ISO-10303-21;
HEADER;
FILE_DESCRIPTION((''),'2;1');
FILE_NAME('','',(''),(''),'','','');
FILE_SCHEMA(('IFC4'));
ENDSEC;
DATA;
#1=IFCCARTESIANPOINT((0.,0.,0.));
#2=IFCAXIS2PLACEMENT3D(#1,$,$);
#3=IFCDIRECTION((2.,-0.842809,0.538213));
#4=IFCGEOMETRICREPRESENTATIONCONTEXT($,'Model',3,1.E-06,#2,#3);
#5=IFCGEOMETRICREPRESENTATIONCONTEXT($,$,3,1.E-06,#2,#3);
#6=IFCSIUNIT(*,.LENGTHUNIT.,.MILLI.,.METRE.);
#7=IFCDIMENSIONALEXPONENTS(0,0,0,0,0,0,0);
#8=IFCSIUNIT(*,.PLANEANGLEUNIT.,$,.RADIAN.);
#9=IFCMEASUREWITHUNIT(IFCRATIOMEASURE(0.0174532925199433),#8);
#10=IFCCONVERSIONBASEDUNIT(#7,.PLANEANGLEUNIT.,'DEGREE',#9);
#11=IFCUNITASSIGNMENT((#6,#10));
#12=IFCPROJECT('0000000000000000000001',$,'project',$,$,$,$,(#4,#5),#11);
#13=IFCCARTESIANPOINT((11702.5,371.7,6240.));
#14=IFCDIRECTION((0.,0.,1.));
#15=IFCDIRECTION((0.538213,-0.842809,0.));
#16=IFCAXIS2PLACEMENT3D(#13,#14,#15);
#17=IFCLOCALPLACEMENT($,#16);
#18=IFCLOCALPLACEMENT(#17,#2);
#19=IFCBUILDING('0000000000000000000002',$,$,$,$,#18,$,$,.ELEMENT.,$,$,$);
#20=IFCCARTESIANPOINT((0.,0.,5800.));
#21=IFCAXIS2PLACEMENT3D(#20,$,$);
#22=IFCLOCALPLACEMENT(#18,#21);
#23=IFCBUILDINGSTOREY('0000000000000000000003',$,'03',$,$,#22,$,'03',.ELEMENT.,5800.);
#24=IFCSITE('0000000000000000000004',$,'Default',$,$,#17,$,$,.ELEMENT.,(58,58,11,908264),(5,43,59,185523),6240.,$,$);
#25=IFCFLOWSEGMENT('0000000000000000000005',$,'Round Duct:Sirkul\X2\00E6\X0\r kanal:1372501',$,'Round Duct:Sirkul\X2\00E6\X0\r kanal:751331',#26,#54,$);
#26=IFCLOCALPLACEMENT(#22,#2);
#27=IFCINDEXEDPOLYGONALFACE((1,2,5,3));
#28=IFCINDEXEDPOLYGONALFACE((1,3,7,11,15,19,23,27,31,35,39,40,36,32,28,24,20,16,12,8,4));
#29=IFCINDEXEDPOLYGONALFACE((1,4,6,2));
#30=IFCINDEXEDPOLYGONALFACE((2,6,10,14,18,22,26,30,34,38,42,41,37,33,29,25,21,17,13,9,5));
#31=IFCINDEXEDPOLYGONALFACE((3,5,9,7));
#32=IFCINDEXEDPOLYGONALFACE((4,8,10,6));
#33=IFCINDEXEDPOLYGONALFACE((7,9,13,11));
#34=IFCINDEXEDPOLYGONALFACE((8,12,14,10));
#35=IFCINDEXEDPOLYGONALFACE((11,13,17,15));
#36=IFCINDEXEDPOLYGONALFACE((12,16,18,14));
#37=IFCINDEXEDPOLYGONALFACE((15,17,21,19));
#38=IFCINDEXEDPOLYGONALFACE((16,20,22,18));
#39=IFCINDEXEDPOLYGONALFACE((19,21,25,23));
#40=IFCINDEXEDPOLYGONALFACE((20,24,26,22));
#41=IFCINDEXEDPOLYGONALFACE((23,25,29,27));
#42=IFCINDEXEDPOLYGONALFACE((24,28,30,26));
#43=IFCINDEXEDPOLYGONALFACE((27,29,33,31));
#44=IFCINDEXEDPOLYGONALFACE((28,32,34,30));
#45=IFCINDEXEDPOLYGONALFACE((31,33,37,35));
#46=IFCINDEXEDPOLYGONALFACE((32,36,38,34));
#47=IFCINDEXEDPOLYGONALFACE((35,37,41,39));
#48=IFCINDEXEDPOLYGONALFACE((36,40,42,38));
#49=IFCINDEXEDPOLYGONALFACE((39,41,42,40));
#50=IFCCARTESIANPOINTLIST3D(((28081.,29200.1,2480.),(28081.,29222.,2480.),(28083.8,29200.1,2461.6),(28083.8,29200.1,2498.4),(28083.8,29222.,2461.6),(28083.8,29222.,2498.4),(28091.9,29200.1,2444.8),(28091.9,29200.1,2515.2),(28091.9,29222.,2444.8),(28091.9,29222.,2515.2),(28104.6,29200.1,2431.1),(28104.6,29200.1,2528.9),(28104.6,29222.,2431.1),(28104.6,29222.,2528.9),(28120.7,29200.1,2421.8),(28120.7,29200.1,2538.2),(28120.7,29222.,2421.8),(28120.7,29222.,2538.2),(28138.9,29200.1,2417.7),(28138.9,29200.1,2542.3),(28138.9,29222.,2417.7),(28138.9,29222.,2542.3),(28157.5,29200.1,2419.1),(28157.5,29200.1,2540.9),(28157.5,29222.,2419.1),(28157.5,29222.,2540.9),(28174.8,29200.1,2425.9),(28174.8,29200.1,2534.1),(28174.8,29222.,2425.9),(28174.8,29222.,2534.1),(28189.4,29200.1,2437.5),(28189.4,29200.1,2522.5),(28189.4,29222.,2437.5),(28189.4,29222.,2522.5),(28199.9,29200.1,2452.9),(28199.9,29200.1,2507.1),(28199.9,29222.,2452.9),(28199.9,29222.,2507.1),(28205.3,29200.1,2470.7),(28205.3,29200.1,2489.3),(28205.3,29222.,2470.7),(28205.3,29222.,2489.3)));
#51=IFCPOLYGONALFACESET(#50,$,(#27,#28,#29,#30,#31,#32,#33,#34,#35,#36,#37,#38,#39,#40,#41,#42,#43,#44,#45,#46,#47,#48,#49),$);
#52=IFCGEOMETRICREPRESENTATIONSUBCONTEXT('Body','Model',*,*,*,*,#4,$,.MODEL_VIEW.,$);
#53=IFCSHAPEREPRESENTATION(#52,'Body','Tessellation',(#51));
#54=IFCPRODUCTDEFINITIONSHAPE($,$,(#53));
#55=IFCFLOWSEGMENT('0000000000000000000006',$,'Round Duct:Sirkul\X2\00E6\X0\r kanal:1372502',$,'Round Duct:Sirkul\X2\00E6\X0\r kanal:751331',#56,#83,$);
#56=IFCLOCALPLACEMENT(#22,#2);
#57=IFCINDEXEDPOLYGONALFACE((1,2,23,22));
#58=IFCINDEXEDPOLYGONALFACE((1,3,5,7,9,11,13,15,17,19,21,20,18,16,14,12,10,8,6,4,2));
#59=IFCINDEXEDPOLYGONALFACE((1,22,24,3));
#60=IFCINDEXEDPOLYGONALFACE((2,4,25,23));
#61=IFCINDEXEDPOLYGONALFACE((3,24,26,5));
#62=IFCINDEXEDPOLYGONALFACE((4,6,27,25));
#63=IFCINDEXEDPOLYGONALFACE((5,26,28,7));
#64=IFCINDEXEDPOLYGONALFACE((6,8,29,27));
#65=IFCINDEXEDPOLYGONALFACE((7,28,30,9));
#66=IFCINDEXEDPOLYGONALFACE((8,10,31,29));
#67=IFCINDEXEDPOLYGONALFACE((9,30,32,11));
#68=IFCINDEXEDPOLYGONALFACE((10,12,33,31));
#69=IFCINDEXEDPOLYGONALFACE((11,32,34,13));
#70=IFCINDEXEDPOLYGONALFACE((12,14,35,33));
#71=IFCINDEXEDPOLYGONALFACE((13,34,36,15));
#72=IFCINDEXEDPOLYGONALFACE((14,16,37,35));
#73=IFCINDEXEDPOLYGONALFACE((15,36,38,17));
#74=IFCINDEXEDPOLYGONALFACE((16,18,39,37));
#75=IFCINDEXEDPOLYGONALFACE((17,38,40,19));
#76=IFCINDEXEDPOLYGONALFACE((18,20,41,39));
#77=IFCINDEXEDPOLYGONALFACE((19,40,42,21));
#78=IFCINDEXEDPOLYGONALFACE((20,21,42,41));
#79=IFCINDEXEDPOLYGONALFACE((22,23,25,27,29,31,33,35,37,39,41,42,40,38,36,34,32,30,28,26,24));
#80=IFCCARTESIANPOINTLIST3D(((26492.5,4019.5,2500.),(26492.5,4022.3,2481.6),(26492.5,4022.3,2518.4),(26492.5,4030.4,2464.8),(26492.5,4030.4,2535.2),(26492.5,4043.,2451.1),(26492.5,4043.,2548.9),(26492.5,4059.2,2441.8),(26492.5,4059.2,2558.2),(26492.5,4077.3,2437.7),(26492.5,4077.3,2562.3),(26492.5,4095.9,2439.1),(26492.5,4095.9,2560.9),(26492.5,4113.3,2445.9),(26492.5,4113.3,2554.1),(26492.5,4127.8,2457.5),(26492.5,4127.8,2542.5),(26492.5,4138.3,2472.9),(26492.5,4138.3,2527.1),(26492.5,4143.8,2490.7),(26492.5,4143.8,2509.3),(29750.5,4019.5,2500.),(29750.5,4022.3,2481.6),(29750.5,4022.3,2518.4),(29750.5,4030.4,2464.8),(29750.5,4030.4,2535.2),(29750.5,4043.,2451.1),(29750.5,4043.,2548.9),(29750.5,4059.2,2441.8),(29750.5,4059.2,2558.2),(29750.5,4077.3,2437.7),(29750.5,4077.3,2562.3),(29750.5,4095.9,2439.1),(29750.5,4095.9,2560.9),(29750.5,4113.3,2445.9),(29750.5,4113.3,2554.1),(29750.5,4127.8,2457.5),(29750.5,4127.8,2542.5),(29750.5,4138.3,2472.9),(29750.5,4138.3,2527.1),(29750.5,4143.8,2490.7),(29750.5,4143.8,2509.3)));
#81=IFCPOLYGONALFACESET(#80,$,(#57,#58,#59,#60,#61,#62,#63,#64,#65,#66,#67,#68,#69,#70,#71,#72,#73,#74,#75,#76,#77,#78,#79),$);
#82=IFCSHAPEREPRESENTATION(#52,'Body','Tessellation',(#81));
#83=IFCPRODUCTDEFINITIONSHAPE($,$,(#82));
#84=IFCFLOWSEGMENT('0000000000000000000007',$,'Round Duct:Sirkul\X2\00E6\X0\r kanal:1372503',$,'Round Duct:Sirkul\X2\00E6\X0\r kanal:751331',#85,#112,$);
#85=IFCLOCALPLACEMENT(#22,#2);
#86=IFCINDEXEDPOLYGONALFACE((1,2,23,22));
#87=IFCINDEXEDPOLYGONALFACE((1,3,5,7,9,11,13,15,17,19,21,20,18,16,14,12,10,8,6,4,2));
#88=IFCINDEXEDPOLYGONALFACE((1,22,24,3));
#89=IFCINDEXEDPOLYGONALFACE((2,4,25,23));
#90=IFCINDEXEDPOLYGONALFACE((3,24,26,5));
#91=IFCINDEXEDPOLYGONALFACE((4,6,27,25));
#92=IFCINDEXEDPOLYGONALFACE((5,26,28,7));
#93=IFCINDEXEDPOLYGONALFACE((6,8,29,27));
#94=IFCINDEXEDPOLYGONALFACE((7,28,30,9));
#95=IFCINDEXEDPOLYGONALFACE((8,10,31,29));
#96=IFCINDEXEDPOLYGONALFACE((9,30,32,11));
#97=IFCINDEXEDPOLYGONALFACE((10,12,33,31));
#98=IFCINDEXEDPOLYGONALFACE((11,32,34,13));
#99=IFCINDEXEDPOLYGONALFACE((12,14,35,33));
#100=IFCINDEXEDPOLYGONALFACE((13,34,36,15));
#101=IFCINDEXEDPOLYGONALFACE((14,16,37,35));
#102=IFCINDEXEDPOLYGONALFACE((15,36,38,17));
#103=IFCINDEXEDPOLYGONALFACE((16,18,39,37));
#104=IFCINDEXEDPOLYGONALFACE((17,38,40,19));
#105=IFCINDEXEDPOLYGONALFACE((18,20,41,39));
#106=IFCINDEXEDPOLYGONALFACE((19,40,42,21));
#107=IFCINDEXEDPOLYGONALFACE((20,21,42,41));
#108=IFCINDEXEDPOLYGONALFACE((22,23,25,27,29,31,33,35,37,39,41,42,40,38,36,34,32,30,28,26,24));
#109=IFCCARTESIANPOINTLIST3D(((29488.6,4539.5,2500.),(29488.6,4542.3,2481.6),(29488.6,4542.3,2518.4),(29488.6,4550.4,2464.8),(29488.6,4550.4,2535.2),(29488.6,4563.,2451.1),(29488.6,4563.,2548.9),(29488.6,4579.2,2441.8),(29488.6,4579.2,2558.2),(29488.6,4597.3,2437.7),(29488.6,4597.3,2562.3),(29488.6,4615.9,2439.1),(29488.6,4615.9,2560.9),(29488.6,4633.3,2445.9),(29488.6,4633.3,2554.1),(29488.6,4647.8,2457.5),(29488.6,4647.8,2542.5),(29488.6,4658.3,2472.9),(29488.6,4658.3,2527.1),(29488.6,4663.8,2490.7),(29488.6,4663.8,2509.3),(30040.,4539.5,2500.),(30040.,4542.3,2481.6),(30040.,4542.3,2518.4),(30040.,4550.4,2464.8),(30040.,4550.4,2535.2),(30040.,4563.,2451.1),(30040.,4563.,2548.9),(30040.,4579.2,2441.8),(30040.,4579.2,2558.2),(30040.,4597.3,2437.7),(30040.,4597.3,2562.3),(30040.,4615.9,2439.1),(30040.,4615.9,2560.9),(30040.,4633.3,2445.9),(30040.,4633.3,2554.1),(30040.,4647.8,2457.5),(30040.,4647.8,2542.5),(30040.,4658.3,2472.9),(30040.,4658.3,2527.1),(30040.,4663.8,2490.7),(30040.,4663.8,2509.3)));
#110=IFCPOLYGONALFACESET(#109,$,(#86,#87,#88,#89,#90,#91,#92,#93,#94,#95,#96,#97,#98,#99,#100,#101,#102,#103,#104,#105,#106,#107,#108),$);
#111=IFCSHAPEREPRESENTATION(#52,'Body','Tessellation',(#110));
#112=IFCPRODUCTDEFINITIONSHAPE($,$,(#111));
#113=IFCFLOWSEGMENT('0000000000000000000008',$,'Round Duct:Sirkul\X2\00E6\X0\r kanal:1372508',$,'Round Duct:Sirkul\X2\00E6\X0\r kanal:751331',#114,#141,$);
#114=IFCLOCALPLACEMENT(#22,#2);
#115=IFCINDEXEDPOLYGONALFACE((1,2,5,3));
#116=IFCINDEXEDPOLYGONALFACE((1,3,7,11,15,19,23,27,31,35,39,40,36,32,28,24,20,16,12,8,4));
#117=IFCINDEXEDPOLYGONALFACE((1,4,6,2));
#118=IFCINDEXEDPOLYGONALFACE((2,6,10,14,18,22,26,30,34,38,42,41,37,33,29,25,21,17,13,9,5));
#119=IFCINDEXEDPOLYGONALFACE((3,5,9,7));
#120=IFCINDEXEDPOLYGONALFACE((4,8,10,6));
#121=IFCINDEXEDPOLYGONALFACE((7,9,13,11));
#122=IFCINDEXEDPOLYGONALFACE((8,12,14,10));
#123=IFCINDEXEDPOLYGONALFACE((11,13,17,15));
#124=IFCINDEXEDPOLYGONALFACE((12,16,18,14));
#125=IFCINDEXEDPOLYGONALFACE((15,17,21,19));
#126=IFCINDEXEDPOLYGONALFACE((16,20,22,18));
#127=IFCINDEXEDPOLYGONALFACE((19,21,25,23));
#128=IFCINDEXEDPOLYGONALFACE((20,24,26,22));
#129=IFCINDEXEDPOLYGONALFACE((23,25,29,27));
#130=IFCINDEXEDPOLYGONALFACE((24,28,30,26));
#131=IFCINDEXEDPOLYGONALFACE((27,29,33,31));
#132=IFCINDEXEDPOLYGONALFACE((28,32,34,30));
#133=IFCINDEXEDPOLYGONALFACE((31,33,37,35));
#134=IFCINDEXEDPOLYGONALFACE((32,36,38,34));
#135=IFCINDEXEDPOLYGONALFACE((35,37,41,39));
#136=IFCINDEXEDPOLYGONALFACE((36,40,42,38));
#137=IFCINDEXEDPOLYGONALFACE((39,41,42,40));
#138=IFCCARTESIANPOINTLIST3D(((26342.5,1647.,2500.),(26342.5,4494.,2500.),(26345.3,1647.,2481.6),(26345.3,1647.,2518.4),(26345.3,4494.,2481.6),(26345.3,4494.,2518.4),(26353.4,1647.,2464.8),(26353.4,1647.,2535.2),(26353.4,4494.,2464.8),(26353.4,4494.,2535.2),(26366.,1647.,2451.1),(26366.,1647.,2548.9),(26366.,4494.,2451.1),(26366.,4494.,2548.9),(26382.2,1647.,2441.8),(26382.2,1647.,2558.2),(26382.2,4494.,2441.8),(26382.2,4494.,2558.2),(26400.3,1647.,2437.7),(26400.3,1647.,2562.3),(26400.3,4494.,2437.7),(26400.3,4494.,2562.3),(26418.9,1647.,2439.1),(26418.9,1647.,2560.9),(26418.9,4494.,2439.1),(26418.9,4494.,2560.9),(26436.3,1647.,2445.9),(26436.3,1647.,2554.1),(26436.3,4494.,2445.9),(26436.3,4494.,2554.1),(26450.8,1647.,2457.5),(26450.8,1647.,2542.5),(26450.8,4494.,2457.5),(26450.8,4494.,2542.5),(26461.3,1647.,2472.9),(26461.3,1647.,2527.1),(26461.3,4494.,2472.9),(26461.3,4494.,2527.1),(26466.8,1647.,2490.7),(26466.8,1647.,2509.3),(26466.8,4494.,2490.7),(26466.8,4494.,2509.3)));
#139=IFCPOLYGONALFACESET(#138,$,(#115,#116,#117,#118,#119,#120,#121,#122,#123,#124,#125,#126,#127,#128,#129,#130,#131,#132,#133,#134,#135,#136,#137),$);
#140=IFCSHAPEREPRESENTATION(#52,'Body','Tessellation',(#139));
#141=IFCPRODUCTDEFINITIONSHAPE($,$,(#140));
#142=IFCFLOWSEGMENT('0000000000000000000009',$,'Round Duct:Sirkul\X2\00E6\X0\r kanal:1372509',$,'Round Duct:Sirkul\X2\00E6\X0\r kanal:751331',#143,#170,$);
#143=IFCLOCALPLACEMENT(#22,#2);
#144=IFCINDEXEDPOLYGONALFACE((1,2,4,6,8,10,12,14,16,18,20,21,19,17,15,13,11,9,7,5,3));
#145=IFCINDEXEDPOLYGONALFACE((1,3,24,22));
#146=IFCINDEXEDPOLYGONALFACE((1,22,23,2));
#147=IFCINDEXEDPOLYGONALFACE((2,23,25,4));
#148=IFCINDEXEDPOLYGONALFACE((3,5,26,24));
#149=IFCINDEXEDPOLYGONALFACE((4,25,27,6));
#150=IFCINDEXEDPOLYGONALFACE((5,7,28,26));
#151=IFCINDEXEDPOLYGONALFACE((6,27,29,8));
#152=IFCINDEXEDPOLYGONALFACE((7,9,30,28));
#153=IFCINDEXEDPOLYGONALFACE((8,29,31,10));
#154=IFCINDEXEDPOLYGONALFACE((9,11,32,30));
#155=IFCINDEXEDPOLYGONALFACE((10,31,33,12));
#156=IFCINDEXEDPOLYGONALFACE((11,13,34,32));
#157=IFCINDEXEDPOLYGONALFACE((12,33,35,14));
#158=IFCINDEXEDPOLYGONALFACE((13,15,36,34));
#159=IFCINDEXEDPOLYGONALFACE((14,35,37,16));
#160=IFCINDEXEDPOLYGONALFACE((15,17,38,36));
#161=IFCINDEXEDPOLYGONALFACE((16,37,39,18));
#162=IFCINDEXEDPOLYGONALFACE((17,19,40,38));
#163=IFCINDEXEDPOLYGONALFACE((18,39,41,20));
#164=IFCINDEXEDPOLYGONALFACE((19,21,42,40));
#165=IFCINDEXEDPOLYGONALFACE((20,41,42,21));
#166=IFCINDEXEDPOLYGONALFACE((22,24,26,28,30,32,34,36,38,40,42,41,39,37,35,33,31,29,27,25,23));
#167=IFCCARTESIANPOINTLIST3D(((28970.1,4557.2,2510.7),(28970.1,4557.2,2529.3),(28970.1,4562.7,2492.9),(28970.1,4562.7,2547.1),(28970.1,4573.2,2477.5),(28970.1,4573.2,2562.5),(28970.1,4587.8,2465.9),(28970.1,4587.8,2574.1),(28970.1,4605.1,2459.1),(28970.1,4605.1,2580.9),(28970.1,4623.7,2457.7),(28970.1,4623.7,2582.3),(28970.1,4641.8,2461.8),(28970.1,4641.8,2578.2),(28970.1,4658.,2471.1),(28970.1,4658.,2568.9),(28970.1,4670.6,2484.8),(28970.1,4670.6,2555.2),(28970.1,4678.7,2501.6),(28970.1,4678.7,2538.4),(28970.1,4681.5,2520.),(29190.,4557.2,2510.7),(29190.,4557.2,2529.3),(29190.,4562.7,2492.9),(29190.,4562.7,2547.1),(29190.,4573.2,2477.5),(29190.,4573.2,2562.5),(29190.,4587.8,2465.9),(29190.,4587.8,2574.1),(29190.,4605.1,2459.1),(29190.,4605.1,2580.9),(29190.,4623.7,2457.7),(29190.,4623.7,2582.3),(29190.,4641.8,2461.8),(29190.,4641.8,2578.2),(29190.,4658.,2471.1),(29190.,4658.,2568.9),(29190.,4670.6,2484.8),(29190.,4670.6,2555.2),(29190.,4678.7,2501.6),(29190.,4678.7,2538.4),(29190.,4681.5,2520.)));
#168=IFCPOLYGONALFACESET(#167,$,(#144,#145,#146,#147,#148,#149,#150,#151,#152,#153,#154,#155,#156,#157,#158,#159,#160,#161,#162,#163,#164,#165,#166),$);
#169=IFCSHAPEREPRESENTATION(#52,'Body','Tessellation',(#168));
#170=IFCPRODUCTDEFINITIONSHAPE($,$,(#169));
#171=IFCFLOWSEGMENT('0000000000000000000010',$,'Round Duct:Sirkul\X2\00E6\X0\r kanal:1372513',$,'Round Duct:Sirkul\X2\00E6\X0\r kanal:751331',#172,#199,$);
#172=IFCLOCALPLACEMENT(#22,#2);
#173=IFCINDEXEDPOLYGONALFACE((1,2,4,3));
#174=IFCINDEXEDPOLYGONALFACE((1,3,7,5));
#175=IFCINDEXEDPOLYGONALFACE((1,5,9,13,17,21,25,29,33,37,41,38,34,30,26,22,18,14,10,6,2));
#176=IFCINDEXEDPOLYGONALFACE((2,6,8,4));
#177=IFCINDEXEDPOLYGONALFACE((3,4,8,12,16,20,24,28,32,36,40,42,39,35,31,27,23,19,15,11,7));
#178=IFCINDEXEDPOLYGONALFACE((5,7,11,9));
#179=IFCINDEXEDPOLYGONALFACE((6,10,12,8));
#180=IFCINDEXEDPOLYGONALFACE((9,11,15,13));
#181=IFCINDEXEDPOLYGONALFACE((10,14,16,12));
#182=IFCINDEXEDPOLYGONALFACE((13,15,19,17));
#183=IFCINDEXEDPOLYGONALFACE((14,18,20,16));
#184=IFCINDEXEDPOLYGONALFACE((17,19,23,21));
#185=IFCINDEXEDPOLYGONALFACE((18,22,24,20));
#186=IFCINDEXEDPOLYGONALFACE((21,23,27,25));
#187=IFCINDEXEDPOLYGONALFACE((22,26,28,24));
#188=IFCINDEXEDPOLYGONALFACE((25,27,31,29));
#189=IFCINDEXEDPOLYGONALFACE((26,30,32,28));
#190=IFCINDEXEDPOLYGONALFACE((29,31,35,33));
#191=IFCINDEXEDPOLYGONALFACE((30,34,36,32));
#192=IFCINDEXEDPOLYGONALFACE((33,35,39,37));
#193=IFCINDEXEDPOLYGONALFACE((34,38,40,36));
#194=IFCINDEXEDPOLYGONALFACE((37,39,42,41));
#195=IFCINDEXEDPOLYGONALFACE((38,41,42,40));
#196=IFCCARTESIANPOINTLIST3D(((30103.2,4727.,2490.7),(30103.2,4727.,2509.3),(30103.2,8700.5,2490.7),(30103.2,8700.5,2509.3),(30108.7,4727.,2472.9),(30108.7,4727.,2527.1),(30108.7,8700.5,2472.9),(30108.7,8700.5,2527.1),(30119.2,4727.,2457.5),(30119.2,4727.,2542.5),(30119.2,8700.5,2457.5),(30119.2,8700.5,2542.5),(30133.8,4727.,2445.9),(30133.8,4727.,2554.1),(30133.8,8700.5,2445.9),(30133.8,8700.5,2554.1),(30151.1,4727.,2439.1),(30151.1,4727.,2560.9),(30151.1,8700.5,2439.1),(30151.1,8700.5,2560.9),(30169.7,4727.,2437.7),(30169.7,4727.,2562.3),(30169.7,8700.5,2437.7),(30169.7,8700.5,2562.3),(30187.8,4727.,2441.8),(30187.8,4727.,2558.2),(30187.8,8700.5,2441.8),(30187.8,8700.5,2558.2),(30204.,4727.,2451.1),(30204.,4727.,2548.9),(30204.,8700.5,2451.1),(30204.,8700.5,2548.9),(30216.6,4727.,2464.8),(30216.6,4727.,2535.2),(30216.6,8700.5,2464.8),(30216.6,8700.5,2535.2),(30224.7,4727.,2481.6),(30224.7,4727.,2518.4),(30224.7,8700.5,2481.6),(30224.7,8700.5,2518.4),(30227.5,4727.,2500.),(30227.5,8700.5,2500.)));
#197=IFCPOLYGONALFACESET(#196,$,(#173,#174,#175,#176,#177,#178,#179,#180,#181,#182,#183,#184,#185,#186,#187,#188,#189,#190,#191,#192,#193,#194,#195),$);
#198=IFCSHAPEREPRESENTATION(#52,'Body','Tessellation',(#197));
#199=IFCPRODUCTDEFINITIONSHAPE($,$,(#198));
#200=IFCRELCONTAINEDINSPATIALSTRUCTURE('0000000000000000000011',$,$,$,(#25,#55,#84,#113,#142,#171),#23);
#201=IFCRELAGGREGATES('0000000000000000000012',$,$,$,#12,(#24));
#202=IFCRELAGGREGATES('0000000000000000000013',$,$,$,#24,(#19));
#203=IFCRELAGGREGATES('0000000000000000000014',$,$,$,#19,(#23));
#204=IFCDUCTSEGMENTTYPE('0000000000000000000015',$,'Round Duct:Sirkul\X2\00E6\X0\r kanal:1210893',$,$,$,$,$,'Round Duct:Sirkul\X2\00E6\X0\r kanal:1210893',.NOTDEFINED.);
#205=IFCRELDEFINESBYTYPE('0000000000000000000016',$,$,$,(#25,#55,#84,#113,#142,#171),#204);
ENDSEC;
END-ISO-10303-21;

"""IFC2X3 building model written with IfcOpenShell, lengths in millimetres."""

from ifc_helpers import new_model, entity, si_unit, converted_unit, direction, frame, frame_2d, origin, origin_2d_with_axis, place, context, subcontext, project, spatial, circle, extrude, type_object, element, save


model = new_model("IFC2X3")

# Units and contexts
model_context = context("Model", 3, precision=1e-06, world=origin(), true_north=direction((2.0, -0.842809, 0.538213)))
context_of_model = context(None, 3, precision=1e-06, world=origin(), true_north=direction((2.0, -0.842809, 0.538213)))
body_context = subcontext(model_context, "Body", "Model", "MODEL_VIEW")
ifc_project = project(units=[si_unit("LENGTHUNIT", "METRE", prefix="MILLI"), converted_unit("PLANEANGLEUNIT", "DEGREE", entity("IfcRatioMeasure", 0.0174532925199433), si_unit("PLANEANGLEUNIT", "RADIAN"), dimensions=[0, 0, 0, 0, 0, 0, 0])], contexts=[model_context, context_of_model])

# Site, building, storey
site_placement = place(None, frame((11702.5, 371.7, 6240.0), z_axis=(0.0, 0.0, 1.0), x_axis=(0.538213, -0.842809, 0.0)))
site = spatial("IfcSite", under=ifc_project, at=site_placement, Name="Default", CompositionType="ELEMENT", RefLatitude=(58, 58, 11, 908264), RefLongitude=(5, 43, 59, 185523), RefElevation=6240.0)
building_placement = place(site_placement, origin())
building = spatial("IfcBuilding", under=site, at=building_placement, CompositionType="ELEMENT")
storey_placement = place(building_placement, frame((0.0, 0.0, 5800.0)))
storey = spatial("IfcBuildingStorey", under=building, at=storey_placement, Name="03", LongName="03", CompositionType="ELEMENT", Elevation=5800.0)

# Flow segments
duct_segment_type_1 = type_object("IfcDuctSegmentType", Name="Round Duct:Sirkulær kanal:1210893", ElementType="Round Duct:Sirkulær kanal:1210893", PredefinedType="NOTDEFINED")
flow_segment_1_placement = place(storey_placement, origin())
element("IfcFlowSegment", 1, at=flow_segment_1_placement, inside=storey, type_object=duct_segment_type_1, Name="Round Duct:Sirkulær kanal:1372501", ObjectType="Round Duct:Sirkulær kanal:751331", context=body_context, shape_type="SweptSolid", body=[
    extrude(circle(Radius=62.5, at=origin_2d_with_axis()), frame((28143.5, 29200.1, 2480.0), z_axis=(0.0, 1.0, 0.0), x_axis=(-1.0, 0.0, 0.0)), (0.0, 0.0, 1.0), 21.9),
])
flow_segment_2_placement = place(storey_placement, origin())
element("IfcFlowSegment", 2, at=flow_segment_2_placement, inside=storey, type_object=duct_segment_type_1, Name="Round Duct:Sirkulær kanal:1372502", ObjectType="Round Duct:Sirkulær kanal:751331", context=body_context, shape_type="SweptSolid", body=[
    extrude(circle(Radius=62.5, at=frame_2d((0.0, 0.0), x_axis=(1.0, 0.0))), frame((26492.5, 4082.0, 2500.0), z_axis=(1.0, 0.0, 0.0), x_axis=(0.0, -1.0, 0.0)), (0.0, 0.0, 1.0), 3258.0),
])
flow_segment_3_placement = place(storey_placement, origin())
element("IfcFlowSegment", 3, at=flow_segment_3_placement, inside=storey, type_object=duct_segment_type_1, Name="Round Duct:Sirkulær kanal:1372503", ObjectType="Round Duct:Sirkulær kanal:751331", context=body_context, shape_type="SweptSolid", body=[
    extrude(circle(Radius=62.5, at=origin_2d_with_axis()), frame((29488.6, 4602.0, 2500.0), z_axis=(1.0, 0.0, 0.0), x_axis=(0.0, -1.0, 0.0)), (0.0, 0.0, 1.0), 551.4),
])
flow_segment_4_placement = place(storey_placement, origin())
element("IfcFlowSegment", 4, at=flow_segment_4_placement, inside=storey, type_object=duct_segment_type_1, Name="Round Duct:Sirkulær kanal:1372508", ObjectType="Round Duct:Sirkulær kanal:751331", context=body_context, shape_type="SweptSolid", body=[
    extrude(circle(Radius=62.5, at=frame_2d((0.0, 0.0), x_axis=(1.0, 0.0))), frame((26405.0, 1647.0, 2500.0), z_axis=(0.0, 1.0, 0.0), x_axis=(-1.0, 0.0, 0.0)), (0.0, 0.0, 1.0), 2847.0),
])
flow_segment_5_placement = place(storey_placement, origin())
element("IfcFlowSegment", 5, at=flow_segment_5_placement, inside=storey, type_object=duct_segment_type_1, Name="Round Duct:Sirkulær kanal:1372509", ObjectType="Round Duct:Sirkulær kanal:751331", context=body_context, shape_type="SweptSolid", body=[
    extrude(circle(Radius=62.5, at=frame_2d((0.0, 0.0), x_axis=(1.0, 0.0))), frame((28970.1, 4619.0, 2520.0), z_axis=(1.0, 0.0, 0.0), x_axis=(0.0, 1.0, 0.0)), (0.0, 0.0, 1.0), 219.9),
])
flow_segment_6_placement = place(storey_placement, origin())
element("IfcFlowSegment", 6, at=flow_segment_6_placement, inside=storey, type_object=duct_segment_type_1, Name="Round Duct:Sirkulær kanal:1372513", ObjectType="Round Duct:Sirkulær kanal:751331", context=body_context, shape_type="SweptSolid", body=[
    extrude(circle(Radius=62.5, at=origin_2d_with_axis()), frame((30165.0, 4727.0, 2500.0), z_axis=(0.0, 1.0, 0.0), x_axis=(1.0, 0.0, 0.0)), (0.0, 0.0, 1.0), 3973.5),
])

save(model, "model.ifc")
